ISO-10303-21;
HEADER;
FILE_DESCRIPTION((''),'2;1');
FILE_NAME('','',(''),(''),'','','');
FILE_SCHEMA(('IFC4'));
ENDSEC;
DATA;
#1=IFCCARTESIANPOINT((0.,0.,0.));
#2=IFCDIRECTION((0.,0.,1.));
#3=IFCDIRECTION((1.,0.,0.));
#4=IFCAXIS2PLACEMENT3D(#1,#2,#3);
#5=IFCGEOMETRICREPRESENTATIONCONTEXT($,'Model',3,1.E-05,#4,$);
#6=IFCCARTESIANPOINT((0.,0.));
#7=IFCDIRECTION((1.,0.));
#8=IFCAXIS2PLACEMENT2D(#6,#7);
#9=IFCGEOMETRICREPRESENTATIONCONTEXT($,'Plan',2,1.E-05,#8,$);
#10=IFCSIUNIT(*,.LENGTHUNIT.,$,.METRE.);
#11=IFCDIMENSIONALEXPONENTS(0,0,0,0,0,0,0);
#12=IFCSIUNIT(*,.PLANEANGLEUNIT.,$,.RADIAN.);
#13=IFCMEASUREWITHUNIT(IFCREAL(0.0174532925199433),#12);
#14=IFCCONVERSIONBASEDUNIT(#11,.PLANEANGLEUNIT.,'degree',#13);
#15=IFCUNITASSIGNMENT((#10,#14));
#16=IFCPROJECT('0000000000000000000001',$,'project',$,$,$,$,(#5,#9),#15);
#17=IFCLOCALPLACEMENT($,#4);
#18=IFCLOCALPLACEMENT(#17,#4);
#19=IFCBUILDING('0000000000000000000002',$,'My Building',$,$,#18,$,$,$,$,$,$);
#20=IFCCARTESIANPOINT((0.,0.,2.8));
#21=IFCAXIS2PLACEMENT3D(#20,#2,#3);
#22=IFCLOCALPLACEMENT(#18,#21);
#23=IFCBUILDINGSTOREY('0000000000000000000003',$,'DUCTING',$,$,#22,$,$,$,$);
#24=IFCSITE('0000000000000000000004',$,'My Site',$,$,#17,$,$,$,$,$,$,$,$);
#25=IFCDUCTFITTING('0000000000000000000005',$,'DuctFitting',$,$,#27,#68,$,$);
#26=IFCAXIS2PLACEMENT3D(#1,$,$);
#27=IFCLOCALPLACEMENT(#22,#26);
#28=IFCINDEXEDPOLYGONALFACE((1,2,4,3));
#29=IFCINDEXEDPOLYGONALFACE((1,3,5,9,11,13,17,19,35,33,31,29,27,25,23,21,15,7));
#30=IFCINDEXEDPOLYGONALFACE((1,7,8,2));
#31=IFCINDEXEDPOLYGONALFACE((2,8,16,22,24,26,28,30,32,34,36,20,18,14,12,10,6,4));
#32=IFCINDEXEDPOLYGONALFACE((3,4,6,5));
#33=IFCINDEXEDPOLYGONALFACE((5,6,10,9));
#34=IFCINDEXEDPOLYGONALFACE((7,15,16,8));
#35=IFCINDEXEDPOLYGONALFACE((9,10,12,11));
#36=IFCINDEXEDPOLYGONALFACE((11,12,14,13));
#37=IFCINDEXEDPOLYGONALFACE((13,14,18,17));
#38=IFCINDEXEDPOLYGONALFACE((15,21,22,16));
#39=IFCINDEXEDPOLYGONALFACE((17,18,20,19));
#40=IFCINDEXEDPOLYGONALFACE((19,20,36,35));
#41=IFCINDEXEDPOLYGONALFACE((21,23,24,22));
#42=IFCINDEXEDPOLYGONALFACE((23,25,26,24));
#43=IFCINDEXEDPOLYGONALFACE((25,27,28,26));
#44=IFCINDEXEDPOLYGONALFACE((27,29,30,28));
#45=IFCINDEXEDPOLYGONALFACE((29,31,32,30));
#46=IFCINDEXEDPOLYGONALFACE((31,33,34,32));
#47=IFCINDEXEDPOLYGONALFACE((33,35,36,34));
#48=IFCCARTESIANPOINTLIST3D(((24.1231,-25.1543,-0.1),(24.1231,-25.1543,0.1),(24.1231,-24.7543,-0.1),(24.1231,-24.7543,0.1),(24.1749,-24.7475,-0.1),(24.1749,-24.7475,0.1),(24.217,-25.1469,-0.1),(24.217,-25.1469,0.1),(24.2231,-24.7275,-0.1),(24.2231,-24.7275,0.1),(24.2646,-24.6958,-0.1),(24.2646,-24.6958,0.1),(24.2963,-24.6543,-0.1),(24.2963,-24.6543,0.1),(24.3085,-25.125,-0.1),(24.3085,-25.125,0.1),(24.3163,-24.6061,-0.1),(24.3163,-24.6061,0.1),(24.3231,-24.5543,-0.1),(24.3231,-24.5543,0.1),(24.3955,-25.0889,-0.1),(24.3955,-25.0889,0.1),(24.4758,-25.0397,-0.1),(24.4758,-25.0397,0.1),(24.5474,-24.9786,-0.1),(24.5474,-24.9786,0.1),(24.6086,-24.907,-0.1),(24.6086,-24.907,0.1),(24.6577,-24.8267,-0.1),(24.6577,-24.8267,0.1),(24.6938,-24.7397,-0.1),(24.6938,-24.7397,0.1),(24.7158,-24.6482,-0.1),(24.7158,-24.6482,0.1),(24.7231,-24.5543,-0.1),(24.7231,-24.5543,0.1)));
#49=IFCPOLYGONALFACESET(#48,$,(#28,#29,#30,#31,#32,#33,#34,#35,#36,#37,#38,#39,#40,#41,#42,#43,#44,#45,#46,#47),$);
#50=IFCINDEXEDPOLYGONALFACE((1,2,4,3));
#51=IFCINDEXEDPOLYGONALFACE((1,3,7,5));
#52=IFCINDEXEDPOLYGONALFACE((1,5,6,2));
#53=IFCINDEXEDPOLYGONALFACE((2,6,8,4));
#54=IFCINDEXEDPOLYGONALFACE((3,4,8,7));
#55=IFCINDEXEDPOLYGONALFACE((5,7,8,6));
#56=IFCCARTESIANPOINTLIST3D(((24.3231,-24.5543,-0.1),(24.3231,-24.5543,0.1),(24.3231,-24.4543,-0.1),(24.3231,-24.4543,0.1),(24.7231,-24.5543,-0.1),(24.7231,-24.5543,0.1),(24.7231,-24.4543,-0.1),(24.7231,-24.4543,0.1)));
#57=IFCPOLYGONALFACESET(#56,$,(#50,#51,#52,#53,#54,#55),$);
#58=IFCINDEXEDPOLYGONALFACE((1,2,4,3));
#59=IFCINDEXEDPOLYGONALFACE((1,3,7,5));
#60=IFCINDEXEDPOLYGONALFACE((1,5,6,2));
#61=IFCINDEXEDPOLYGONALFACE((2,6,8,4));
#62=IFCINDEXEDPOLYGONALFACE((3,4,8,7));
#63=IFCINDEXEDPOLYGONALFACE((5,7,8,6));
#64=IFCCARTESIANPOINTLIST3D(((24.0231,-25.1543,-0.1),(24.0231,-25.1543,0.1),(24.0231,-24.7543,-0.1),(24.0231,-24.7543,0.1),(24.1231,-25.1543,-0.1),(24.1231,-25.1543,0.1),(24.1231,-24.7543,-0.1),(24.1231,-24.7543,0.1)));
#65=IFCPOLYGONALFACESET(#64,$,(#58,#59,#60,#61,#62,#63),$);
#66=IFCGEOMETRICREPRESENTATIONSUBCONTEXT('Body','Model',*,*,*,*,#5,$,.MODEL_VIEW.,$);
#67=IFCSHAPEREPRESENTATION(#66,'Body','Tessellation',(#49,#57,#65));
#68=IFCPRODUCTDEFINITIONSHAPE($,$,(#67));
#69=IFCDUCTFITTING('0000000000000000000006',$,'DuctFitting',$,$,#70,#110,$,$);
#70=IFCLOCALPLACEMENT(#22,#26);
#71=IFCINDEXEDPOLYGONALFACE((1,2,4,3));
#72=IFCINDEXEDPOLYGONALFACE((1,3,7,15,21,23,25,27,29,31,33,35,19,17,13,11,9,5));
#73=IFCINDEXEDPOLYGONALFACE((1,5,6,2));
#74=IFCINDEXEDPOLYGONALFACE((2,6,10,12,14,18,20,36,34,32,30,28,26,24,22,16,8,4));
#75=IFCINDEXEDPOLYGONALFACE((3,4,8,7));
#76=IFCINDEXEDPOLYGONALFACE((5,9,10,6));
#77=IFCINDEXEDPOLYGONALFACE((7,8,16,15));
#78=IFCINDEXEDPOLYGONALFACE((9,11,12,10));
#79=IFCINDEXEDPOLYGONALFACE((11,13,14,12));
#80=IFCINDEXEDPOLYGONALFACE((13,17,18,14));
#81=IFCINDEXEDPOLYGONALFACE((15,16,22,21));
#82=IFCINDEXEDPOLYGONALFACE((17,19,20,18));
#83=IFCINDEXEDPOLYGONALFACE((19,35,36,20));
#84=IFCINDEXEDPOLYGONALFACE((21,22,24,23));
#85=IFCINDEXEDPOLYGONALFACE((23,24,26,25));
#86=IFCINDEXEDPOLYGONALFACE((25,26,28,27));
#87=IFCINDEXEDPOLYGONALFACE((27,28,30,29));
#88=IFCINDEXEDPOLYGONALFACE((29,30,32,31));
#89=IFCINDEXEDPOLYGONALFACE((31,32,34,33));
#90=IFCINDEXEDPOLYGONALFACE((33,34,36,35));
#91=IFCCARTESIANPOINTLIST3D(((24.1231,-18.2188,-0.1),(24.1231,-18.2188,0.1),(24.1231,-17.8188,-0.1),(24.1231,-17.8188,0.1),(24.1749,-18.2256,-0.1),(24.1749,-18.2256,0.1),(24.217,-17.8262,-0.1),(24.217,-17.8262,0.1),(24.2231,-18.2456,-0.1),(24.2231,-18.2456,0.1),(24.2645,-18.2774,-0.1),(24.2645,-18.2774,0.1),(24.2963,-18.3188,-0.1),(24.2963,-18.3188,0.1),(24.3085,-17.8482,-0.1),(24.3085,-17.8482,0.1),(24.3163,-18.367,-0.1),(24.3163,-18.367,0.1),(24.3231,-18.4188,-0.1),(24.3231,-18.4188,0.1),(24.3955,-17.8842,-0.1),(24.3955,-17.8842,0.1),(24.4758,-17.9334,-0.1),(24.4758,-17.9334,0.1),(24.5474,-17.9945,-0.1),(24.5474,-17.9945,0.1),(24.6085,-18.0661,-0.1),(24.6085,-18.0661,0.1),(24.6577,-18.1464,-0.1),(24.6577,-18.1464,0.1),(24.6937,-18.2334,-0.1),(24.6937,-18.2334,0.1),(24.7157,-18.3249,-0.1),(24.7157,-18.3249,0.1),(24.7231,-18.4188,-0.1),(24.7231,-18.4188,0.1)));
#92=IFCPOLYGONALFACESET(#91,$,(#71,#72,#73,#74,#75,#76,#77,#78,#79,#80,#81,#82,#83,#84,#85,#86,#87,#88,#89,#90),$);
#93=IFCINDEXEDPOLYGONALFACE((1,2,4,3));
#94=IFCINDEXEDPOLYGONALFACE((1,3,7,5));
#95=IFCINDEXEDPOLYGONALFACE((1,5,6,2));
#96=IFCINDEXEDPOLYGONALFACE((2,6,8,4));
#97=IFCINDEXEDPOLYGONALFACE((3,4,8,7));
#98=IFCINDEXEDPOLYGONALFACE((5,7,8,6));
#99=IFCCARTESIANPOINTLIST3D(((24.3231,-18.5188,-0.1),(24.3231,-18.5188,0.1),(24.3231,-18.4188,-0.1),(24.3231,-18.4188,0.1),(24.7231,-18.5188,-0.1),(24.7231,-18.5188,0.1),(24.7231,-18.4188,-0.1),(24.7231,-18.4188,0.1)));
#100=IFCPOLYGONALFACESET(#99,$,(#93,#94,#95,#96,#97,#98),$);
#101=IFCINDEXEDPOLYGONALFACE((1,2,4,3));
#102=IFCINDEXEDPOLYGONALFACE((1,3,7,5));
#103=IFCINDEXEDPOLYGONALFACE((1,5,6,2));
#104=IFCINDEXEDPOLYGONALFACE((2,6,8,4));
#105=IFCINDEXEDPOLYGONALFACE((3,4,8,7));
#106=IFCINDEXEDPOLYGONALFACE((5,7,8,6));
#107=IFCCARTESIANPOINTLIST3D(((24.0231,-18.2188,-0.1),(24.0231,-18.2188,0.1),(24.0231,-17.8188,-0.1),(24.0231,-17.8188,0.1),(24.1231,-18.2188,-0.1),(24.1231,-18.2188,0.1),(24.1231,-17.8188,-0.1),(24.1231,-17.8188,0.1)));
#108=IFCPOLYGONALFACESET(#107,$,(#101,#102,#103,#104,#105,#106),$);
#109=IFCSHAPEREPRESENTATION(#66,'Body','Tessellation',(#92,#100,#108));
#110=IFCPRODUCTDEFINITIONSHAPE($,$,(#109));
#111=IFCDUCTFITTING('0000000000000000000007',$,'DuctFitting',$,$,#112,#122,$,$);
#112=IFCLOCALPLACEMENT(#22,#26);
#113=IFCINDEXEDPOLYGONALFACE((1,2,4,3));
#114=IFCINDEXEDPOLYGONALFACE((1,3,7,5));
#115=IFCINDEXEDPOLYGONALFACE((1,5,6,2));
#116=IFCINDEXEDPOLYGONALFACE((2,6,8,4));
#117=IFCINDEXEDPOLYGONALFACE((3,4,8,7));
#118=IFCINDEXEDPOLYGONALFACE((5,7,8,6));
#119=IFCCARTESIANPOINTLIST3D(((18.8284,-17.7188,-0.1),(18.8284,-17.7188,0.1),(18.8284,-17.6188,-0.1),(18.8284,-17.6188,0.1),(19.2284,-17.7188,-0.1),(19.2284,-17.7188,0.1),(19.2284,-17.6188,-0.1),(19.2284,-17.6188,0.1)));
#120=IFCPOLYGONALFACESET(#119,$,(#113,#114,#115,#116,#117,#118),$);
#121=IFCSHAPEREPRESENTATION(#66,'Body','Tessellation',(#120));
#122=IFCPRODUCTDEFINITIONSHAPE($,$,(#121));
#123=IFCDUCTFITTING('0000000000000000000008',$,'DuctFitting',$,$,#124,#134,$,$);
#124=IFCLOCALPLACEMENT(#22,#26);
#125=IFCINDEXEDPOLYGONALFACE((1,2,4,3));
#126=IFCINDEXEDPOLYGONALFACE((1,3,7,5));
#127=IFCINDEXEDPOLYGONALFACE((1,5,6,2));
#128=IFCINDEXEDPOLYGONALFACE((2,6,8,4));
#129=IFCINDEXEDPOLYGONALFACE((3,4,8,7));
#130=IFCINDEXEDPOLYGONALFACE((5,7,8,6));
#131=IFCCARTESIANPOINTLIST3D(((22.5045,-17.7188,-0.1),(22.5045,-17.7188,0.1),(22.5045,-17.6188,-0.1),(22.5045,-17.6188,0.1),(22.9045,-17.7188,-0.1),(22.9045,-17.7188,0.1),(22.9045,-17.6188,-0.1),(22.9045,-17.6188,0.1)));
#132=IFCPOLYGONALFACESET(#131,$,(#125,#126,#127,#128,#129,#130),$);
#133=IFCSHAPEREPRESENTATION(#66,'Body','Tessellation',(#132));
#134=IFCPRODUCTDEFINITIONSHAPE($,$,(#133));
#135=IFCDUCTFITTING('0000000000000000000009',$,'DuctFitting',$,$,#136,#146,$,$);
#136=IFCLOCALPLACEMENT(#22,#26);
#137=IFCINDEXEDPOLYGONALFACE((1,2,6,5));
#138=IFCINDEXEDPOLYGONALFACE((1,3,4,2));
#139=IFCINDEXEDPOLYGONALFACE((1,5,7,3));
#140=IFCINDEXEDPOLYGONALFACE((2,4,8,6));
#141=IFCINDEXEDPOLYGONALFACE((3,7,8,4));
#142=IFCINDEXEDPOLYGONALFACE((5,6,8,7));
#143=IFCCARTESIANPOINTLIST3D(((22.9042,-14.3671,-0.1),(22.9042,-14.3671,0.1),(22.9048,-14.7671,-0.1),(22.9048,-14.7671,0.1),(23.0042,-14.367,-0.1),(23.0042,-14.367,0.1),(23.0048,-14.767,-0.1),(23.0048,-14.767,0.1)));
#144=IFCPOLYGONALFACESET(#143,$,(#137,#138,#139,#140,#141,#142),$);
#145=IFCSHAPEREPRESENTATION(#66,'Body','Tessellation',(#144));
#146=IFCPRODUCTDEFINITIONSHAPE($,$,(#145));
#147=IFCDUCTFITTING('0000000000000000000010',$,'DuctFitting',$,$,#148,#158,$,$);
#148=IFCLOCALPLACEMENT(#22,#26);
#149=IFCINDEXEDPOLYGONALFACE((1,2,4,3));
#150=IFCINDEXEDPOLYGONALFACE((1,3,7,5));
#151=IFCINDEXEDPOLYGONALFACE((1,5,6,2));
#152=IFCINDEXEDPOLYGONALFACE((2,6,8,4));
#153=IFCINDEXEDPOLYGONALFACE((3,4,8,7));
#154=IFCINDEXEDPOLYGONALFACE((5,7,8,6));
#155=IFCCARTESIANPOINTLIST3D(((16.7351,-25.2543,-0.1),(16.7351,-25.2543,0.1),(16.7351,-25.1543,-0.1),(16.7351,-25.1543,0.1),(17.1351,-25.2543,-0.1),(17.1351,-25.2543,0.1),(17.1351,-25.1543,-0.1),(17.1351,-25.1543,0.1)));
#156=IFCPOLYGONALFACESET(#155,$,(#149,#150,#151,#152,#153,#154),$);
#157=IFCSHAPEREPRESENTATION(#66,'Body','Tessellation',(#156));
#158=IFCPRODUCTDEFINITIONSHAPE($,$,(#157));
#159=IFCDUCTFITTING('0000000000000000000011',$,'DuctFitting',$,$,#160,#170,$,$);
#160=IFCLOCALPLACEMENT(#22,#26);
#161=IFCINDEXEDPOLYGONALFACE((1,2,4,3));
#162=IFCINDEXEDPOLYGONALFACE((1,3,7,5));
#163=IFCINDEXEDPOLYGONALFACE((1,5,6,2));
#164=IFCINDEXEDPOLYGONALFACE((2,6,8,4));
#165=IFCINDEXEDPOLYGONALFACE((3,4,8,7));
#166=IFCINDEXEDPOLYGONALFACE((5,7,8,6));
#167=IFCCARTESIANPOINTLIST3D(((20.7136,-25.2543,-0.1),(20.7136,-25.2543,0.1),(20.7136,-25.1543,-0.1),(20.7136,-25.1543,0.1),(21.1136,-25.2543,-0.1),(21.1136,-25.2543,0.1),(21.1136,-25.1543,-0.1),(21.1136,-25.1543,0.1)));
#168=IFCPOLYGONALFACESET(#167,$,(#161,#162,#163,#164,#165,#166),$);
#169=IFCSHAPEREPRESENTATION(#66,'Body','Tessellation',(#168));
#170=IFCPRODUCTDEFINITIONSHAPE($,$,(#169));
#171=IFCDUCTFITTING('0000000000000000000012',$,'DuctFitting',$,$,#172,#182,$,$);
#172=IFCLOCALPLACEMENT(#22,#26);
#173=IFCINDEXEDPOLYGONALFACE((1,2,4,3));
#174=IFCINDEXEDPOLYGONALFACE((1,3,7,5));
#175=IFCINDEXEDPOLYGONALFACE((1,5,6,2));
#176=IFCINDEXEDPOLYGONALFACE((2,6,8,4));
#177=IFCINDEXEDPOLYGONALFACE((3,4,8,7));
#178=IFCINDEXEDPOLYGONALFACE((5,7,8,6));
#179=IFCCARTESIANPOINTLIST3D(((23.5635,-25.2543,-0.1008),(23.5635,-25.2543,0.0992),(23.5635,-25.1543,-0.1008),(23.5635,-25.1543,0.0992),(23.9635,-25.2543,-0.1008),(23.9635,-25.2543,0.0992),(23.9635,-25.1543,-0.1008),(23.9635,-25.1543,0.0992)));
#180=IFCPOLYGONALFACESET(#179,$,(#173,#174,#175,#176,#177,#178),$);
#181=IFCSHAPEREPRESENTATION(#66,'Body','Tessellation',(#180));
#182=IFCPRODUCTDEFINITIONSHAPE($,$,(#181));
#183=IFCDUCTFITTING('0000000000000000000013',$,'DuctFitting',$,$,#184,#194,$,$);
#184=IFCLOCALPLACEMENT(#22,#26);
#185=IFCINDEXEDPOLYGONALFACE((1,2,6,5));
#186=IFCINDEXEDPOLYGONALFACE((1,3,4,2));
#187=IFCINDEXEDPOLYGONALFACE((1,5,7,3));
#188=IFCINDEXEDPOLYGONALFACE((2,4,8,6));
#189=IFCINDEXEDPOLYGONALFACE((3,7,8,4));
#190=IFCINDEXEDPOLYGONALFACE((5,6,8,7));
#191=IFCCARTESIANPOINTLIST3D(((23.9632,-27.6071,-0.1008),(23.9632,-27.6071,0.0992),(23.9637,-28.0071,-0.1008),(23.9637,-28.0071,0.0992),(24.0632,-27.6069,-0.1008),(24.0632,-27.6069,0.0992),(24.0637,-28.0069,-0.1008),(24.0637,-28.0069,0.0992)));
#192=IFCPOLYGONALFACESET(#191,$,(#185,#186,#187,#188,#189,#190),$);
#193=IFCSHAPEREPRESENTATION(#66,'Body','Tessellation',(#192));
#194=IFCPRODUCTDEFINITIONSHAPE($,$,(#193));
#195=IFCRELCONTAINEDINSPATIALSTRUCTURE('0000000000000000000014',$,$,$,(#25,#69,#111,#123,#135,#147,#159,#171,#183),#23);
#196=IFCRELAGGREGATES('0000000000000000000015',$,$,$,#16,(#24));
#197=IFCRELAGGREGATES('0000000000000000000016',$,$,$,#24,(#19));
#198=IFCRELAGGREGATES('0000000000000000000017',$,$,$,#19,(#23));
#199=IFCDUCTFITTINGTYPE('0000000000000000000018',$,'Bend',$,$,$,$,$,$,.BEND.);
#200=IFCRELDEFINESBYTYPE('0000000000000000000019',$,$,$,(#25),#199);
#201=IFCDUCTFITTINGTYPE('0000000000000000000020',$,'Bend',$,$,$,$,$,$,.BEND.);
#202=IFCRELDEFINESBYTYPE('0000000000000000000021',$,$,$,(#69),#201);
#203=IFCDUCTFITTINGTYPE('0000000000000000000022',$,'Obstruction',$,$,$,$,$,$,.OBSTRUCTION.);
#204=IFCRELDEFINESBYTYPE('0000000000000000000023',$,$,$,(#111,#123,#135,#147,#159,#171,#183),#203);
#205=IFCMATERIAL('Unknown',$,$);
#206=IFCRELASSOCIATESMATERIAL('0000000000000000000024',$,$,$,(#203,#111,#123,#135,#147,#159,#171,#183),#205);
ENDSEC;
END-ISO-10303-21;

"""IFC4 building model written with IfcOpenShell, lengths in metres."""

from ifc_helpers import new_model, entity, si_unit, converted_unit, frame, origin_with_axes, origin_2d_with_axis, place, context, subcontext, project, spatial, line, arc, indexed_curve, rectangle, outline, extrude, source, transform, mapped, material, material_profile, profile_set, profile_usage, type_object, type_shapes, element, save


model = new_model("IFC4")

# Units and contexts
model_context = context("Model", 3, precision=1e-05, world=origin_with_axes())
plan_context = context("Plan", 2, precision=1e-05, world=origin_2d_with_axis())
body_context = subcontext(model_context, "Body", "Model", "MODEL_VIEW")
ifc_project = project(units=[si_unit("LENGTHUNIT", "METRE"), converted_unit("PLANEANGLEUNIT", "degree", entity("IfcReal", 0.0174532925199433), si_unit("PLANEANGLEUNIT", "RADIAN"), dimensions=[0, 0, 0, 0, 0, 0, 0])], contexts=[model_context, plan_context])

# Site, building, storey
site_placement = place(None, origin_with_axes())
site = spatial("IfcSite", under=ifc_project, at=site_placement, Name="My Site")
building_placement = place(site_placement, origin_with_axes())
building = spatial("IfcBuilding", under=site, at=building_placement, Name="My Building")
storey_placement = place(building_placement, frame((0.0, 0.0, 2.8), z_axis=(0.0, 0.0, 1.0), x_axis=(1.0, 0.0, 0.0)))
storey = spatial("IfcBuildingStorey", under=building, at=storey_placement, Name="DUCTING")

# Shared definitions
ifc_material = material(Name="Unknown")

# Duct fittings
duct_fitting_type_1 = type_object("IfcDuctFittingType", Name="Bend", PredefinedType="BEND")
shared_shape_1 = source(origin_with_axes(), body_context, "Body", "SweptSolid", [
    extrude(outline(indexed_curve([(-0.2, 0.0), (-0.2586, 0.1414), (-0.4, 0.2), (-0.4, 0.6), (0.0243, 0.4243), (0.2, 0.0)], segments=[arc(1, 2, 3), line(3, 4), arc(4, 5, 6), line(6, 1)])), frame((0.0, -0.1, 0.1), z_axis=(0.0, -1.0, 0.0), x_axis=(1.0, 0.0, 0.0)), (0.0, 0.0, -1.0), 0.2),
    extrude(rectangle(XDim=0.4, YDim=0.2), origin_with_axes(), (0.0, 0.0, 1.0), 0.1),
    extrude(rectangle(XDim=0.4, YDim=0.2), frame((-0.4, 0.0, 0.5), z_axis=(-1.0, 0.0, -0.000007), x_axis=(0.000007, 0.0, -1.0)), (0.0, 0.0, 1.0), 0.1),
])
type_shapes(duct_fitting_type_1, [shared_shape_1])
duct_fitting_1_placement = place(storey_placement, frame((24.5231, -24.4543, 0.0), z_axis=(0.000006, -1.0, 0.0), x_axis=(1.0, 0.000006, 0.0)))
element("IfcDuctFitting", 1, at=duct_fitting_1_placement, inside=storey, type_object=duct_fitting_type_1, Name="DuctFitting", context=body_context, shape_type="MappedRepresentation", body=[
    mapped(shared_shape_1, transform((0.0, 0.0, 0.0), x_axis=(1.0, 0.0, 0.0), y_axis=(0.0, 1.0, 0.0), z_axis=(0.0, 0.0, 1.0), scale=1.0)),
])
duct_fitting_type_2 = type_object("IfcDuctFittingType", Name="Bend", PredefinedType="BEND")
shared_shape_2 = source(origin_with_axes(), body_context, "Body", "SweptSolid", [
    extrude(outline(indexed_curve([(-0.2, 0.0), (-0.2586, -0.1414), (-0.4, -0.2), (-0.4, -0.6), (0.0243, -0.4243), (0.2, 0.0)], segments=[arc(1, 2, 3), line(3, 4), arc(4, 5, 6), line(6, 1)])), frame((0.0, -0.1, -0.1), z_axis=(0.0, -1.0, 0.0), x_axis=(1.0, 0.0, 0.0)), (0.0, 0.0, -1.0), 0.2),
    extrude(rectangle(XDim=0.4, YDim=0.2), origin_with_axes(), (0.0, 0.0, -1.0), 0.1),
    extrude(rectangle(XDim=0.4, YDim=0.2), frame((-0.4, 0.0, -0.5), z_axis=(-1.0, 0.0, -0.000007), x_axis=(0.000007, 0.0, -1.0)), (0.0, 0.0, 1.0), 0.1),
])
type_shapes(duct_fitting_type_2, [shared_shape_2])
duct_fitting_2_placement = place(storey_placement, frame((24.5231, -18.5188, 0.0), z_axis=(0.000006, -1.0, 0.0), x_axis=(1.0, 0.000006, 0.0)))
element("IfcDuctFitting", 2, at=duct_fitting_2_placement, inside=storey, type_object=duct_fitting_type_2, Name="DuctFitting", context=body_context, shape_type="MappedRepresentation", body=[
    mapped(shared_shape_2, transform((0.0, 0.0, 0.0), x_axis=(1.0, 0.0, 0.0), y_axis=(0.0, 1.0, 0.0), z_axis=(0.0, 0.0, 1.0), scale=1.0)),
])
ifc_material_profile_1 = material_profile(ifc_material, rectangle(XDim=0.4, YDim=0.2))
ifc_profile_set_1 = profile_set([ifc_material_profile_1])
ifc_profile_usage_1 = profile_usage(ifc_profile_set_1, cardinal=5)
duct_fitting_type_3 = type_object("IfcDuctFittingType", Name="Obstruction", PredefinedType="OBSTRUCTION", material=ifc_profile_set_1)
duct_fitting_3_placement = place(storey_placement, frame((19.0284, -17.7188, 0.0), z_axis=(0.0, 1.0, 0.0), x_axis=(-1.0, 0.0, 0.0)))
element("IfcDuctFitting", 3, at=duct_fitting_3_placement, inside=storey, type_object=duct_fitting_type_3, material=ifc_profile_usage_1, Name="DuctFitting", context=body_context, shape_type="SweptSolid", body=[
    extrude(rectangle(XDim=0.4, YDim=0.2), origin_with_axes(), (0.0, 0.0, 1.0), 0.1),
])
ifc_profile_usage_2 = profile_usage(ifc_profile_set_1, cardinal=5)
duct_fitting_4_placement = place(storey_placement, frame((22.7045, -17.7188, 0.0), z_axis=(0.0, 1.0, 0.0), x_axis=(-1.0, 0.0, 0.0)))
element("IfcDuctFitting", 4, at=duct_fitting_4_placement, inside=storey, type_object=duct_fitting_type_3, material=ifc_profile_usage_2, Name="DuctFitting", context=body_context, shape_type="SweptSolid", body=[
    extrude(rectangle(XDim=0.4, YDim=0.2), origin_with_axes(), (0.0, 0.0, 1.0), 0.1),
])
ifc_profile_usage_3 = profile_usage(ifc_profile_set_1, cardinal=5)
duct_fitting_5_placement = place(storey_placement, frame((22.9045, -14.5671, 0.0), z_axis=(0.999999, 0.001427, 0.0), x_axis=(-0.001427, 0.999999, 0.0)))
element("IfcDuctFitting", 5, at=duct_fitting_5_placement, inside=storey, type_object=duct_fitting_type_3, material=ifc_profile_usage_3, Name="DuctFitting", context=body_context, shape_type="SweptSolid", body=[
    extrude(rectangle(XDim=0.4, YDim=0.2), origin_with_axes(), (0.0, 0.0, 1.0), 0.1),
])
ifc_profile_usage_4 = profile_usage(ifc_profile_set_1, cardinal=5)
duct_fitting_6_placement = place(storey_placement, frame((16.9351, -25.1543, 0.0), z_axis=(0.0, -1.0, 0.0), x_axis=(1.0, 0.0, 0.0)))
element("IfcDuctFitting", 6, at=duct_fitting_6_placement, inside=storey, type_object=duct_fitting_type_3, material=ifc_profile_usage_4, Name="DuctFitting", context=body_context, shape_type="SweptSolid", body=[
    extrude(rectangle(XDim=0.4, YDim=0.2), origin_with_axes(), (0.0, 0.0, 1.0), 0.1),
])
ifc_profile_usage_5 = profile_usage(ifc_profile_set_1, cardinal=5)
duct_fitting_7_placement = place(storey_placement, frame((20.9136, -25.1543, 0.0), z_axis=(0.0, -1.0, 0.0), x_axis=(1.0, 0.0, 0.0)))
element("IfcDuctFitting", 7, at=duct_fitting_7_placement, inside=storey, type_object=duct_fitting_type_3, material=ifc_profile_usage_5, Name="DuctFitting", context=body_context, shape_type="SweptSolid", body=[
    extrude(rectangle(XDim=0.4, YDim=0.2), origin_with_axes(), (0.0, 0.0, 1.0), 0.1),
])
ifc_profile_usage_6 = profile_usage(ifc_profile_set_1, cardinal=5)
duct_fitting_8_placement = place(storey_placement, frame((23.7635, -25.1543, -0.0008), z_axis=(0.0, -1.0, 0.0), x_axis=(1.0, 0.0, 0.0)))
element("IfcDuctFitting", 8, at=duct_fitting_8_placement, inside=storey, type_object=duct_fitting_type_3, material=ifc_profile_usage_6, Name="DuctFitting", context=body_context, shape_type="SweptSolid", body=[
    extrude(rectangle(XDim=0.4, YDim=0.2), origin_with_axes(), (0.0, 0.0, 1.0), 0.1),
])
ifc_profile_usage_7 = profile_usage(ifc_profile_set_1, cardinal=5)
duct_fitting_9_placement = place(storey_placement, frame((23.9635, -27.8071, -0.0008), z_axis=(0.999999, 0.001336, 0.0), x_axis=(-0.001336, 0.999999, 0.0)))
element("IfcDuctFitting", 9, at=duct_fitting_9_placement, inside=storey, type_object=duct_fitting_type_3, material=ifc_profile_usage_7, Name="DuctFitting", context=body_context, shape_type="SweptSolid", body=[
    extrude(rectangle(XDim=0.4, YDim=0.2), origin_with_axes(), (0.0, 0.0, 1.0), 0.1),
])

save(model, "model.ifc")
